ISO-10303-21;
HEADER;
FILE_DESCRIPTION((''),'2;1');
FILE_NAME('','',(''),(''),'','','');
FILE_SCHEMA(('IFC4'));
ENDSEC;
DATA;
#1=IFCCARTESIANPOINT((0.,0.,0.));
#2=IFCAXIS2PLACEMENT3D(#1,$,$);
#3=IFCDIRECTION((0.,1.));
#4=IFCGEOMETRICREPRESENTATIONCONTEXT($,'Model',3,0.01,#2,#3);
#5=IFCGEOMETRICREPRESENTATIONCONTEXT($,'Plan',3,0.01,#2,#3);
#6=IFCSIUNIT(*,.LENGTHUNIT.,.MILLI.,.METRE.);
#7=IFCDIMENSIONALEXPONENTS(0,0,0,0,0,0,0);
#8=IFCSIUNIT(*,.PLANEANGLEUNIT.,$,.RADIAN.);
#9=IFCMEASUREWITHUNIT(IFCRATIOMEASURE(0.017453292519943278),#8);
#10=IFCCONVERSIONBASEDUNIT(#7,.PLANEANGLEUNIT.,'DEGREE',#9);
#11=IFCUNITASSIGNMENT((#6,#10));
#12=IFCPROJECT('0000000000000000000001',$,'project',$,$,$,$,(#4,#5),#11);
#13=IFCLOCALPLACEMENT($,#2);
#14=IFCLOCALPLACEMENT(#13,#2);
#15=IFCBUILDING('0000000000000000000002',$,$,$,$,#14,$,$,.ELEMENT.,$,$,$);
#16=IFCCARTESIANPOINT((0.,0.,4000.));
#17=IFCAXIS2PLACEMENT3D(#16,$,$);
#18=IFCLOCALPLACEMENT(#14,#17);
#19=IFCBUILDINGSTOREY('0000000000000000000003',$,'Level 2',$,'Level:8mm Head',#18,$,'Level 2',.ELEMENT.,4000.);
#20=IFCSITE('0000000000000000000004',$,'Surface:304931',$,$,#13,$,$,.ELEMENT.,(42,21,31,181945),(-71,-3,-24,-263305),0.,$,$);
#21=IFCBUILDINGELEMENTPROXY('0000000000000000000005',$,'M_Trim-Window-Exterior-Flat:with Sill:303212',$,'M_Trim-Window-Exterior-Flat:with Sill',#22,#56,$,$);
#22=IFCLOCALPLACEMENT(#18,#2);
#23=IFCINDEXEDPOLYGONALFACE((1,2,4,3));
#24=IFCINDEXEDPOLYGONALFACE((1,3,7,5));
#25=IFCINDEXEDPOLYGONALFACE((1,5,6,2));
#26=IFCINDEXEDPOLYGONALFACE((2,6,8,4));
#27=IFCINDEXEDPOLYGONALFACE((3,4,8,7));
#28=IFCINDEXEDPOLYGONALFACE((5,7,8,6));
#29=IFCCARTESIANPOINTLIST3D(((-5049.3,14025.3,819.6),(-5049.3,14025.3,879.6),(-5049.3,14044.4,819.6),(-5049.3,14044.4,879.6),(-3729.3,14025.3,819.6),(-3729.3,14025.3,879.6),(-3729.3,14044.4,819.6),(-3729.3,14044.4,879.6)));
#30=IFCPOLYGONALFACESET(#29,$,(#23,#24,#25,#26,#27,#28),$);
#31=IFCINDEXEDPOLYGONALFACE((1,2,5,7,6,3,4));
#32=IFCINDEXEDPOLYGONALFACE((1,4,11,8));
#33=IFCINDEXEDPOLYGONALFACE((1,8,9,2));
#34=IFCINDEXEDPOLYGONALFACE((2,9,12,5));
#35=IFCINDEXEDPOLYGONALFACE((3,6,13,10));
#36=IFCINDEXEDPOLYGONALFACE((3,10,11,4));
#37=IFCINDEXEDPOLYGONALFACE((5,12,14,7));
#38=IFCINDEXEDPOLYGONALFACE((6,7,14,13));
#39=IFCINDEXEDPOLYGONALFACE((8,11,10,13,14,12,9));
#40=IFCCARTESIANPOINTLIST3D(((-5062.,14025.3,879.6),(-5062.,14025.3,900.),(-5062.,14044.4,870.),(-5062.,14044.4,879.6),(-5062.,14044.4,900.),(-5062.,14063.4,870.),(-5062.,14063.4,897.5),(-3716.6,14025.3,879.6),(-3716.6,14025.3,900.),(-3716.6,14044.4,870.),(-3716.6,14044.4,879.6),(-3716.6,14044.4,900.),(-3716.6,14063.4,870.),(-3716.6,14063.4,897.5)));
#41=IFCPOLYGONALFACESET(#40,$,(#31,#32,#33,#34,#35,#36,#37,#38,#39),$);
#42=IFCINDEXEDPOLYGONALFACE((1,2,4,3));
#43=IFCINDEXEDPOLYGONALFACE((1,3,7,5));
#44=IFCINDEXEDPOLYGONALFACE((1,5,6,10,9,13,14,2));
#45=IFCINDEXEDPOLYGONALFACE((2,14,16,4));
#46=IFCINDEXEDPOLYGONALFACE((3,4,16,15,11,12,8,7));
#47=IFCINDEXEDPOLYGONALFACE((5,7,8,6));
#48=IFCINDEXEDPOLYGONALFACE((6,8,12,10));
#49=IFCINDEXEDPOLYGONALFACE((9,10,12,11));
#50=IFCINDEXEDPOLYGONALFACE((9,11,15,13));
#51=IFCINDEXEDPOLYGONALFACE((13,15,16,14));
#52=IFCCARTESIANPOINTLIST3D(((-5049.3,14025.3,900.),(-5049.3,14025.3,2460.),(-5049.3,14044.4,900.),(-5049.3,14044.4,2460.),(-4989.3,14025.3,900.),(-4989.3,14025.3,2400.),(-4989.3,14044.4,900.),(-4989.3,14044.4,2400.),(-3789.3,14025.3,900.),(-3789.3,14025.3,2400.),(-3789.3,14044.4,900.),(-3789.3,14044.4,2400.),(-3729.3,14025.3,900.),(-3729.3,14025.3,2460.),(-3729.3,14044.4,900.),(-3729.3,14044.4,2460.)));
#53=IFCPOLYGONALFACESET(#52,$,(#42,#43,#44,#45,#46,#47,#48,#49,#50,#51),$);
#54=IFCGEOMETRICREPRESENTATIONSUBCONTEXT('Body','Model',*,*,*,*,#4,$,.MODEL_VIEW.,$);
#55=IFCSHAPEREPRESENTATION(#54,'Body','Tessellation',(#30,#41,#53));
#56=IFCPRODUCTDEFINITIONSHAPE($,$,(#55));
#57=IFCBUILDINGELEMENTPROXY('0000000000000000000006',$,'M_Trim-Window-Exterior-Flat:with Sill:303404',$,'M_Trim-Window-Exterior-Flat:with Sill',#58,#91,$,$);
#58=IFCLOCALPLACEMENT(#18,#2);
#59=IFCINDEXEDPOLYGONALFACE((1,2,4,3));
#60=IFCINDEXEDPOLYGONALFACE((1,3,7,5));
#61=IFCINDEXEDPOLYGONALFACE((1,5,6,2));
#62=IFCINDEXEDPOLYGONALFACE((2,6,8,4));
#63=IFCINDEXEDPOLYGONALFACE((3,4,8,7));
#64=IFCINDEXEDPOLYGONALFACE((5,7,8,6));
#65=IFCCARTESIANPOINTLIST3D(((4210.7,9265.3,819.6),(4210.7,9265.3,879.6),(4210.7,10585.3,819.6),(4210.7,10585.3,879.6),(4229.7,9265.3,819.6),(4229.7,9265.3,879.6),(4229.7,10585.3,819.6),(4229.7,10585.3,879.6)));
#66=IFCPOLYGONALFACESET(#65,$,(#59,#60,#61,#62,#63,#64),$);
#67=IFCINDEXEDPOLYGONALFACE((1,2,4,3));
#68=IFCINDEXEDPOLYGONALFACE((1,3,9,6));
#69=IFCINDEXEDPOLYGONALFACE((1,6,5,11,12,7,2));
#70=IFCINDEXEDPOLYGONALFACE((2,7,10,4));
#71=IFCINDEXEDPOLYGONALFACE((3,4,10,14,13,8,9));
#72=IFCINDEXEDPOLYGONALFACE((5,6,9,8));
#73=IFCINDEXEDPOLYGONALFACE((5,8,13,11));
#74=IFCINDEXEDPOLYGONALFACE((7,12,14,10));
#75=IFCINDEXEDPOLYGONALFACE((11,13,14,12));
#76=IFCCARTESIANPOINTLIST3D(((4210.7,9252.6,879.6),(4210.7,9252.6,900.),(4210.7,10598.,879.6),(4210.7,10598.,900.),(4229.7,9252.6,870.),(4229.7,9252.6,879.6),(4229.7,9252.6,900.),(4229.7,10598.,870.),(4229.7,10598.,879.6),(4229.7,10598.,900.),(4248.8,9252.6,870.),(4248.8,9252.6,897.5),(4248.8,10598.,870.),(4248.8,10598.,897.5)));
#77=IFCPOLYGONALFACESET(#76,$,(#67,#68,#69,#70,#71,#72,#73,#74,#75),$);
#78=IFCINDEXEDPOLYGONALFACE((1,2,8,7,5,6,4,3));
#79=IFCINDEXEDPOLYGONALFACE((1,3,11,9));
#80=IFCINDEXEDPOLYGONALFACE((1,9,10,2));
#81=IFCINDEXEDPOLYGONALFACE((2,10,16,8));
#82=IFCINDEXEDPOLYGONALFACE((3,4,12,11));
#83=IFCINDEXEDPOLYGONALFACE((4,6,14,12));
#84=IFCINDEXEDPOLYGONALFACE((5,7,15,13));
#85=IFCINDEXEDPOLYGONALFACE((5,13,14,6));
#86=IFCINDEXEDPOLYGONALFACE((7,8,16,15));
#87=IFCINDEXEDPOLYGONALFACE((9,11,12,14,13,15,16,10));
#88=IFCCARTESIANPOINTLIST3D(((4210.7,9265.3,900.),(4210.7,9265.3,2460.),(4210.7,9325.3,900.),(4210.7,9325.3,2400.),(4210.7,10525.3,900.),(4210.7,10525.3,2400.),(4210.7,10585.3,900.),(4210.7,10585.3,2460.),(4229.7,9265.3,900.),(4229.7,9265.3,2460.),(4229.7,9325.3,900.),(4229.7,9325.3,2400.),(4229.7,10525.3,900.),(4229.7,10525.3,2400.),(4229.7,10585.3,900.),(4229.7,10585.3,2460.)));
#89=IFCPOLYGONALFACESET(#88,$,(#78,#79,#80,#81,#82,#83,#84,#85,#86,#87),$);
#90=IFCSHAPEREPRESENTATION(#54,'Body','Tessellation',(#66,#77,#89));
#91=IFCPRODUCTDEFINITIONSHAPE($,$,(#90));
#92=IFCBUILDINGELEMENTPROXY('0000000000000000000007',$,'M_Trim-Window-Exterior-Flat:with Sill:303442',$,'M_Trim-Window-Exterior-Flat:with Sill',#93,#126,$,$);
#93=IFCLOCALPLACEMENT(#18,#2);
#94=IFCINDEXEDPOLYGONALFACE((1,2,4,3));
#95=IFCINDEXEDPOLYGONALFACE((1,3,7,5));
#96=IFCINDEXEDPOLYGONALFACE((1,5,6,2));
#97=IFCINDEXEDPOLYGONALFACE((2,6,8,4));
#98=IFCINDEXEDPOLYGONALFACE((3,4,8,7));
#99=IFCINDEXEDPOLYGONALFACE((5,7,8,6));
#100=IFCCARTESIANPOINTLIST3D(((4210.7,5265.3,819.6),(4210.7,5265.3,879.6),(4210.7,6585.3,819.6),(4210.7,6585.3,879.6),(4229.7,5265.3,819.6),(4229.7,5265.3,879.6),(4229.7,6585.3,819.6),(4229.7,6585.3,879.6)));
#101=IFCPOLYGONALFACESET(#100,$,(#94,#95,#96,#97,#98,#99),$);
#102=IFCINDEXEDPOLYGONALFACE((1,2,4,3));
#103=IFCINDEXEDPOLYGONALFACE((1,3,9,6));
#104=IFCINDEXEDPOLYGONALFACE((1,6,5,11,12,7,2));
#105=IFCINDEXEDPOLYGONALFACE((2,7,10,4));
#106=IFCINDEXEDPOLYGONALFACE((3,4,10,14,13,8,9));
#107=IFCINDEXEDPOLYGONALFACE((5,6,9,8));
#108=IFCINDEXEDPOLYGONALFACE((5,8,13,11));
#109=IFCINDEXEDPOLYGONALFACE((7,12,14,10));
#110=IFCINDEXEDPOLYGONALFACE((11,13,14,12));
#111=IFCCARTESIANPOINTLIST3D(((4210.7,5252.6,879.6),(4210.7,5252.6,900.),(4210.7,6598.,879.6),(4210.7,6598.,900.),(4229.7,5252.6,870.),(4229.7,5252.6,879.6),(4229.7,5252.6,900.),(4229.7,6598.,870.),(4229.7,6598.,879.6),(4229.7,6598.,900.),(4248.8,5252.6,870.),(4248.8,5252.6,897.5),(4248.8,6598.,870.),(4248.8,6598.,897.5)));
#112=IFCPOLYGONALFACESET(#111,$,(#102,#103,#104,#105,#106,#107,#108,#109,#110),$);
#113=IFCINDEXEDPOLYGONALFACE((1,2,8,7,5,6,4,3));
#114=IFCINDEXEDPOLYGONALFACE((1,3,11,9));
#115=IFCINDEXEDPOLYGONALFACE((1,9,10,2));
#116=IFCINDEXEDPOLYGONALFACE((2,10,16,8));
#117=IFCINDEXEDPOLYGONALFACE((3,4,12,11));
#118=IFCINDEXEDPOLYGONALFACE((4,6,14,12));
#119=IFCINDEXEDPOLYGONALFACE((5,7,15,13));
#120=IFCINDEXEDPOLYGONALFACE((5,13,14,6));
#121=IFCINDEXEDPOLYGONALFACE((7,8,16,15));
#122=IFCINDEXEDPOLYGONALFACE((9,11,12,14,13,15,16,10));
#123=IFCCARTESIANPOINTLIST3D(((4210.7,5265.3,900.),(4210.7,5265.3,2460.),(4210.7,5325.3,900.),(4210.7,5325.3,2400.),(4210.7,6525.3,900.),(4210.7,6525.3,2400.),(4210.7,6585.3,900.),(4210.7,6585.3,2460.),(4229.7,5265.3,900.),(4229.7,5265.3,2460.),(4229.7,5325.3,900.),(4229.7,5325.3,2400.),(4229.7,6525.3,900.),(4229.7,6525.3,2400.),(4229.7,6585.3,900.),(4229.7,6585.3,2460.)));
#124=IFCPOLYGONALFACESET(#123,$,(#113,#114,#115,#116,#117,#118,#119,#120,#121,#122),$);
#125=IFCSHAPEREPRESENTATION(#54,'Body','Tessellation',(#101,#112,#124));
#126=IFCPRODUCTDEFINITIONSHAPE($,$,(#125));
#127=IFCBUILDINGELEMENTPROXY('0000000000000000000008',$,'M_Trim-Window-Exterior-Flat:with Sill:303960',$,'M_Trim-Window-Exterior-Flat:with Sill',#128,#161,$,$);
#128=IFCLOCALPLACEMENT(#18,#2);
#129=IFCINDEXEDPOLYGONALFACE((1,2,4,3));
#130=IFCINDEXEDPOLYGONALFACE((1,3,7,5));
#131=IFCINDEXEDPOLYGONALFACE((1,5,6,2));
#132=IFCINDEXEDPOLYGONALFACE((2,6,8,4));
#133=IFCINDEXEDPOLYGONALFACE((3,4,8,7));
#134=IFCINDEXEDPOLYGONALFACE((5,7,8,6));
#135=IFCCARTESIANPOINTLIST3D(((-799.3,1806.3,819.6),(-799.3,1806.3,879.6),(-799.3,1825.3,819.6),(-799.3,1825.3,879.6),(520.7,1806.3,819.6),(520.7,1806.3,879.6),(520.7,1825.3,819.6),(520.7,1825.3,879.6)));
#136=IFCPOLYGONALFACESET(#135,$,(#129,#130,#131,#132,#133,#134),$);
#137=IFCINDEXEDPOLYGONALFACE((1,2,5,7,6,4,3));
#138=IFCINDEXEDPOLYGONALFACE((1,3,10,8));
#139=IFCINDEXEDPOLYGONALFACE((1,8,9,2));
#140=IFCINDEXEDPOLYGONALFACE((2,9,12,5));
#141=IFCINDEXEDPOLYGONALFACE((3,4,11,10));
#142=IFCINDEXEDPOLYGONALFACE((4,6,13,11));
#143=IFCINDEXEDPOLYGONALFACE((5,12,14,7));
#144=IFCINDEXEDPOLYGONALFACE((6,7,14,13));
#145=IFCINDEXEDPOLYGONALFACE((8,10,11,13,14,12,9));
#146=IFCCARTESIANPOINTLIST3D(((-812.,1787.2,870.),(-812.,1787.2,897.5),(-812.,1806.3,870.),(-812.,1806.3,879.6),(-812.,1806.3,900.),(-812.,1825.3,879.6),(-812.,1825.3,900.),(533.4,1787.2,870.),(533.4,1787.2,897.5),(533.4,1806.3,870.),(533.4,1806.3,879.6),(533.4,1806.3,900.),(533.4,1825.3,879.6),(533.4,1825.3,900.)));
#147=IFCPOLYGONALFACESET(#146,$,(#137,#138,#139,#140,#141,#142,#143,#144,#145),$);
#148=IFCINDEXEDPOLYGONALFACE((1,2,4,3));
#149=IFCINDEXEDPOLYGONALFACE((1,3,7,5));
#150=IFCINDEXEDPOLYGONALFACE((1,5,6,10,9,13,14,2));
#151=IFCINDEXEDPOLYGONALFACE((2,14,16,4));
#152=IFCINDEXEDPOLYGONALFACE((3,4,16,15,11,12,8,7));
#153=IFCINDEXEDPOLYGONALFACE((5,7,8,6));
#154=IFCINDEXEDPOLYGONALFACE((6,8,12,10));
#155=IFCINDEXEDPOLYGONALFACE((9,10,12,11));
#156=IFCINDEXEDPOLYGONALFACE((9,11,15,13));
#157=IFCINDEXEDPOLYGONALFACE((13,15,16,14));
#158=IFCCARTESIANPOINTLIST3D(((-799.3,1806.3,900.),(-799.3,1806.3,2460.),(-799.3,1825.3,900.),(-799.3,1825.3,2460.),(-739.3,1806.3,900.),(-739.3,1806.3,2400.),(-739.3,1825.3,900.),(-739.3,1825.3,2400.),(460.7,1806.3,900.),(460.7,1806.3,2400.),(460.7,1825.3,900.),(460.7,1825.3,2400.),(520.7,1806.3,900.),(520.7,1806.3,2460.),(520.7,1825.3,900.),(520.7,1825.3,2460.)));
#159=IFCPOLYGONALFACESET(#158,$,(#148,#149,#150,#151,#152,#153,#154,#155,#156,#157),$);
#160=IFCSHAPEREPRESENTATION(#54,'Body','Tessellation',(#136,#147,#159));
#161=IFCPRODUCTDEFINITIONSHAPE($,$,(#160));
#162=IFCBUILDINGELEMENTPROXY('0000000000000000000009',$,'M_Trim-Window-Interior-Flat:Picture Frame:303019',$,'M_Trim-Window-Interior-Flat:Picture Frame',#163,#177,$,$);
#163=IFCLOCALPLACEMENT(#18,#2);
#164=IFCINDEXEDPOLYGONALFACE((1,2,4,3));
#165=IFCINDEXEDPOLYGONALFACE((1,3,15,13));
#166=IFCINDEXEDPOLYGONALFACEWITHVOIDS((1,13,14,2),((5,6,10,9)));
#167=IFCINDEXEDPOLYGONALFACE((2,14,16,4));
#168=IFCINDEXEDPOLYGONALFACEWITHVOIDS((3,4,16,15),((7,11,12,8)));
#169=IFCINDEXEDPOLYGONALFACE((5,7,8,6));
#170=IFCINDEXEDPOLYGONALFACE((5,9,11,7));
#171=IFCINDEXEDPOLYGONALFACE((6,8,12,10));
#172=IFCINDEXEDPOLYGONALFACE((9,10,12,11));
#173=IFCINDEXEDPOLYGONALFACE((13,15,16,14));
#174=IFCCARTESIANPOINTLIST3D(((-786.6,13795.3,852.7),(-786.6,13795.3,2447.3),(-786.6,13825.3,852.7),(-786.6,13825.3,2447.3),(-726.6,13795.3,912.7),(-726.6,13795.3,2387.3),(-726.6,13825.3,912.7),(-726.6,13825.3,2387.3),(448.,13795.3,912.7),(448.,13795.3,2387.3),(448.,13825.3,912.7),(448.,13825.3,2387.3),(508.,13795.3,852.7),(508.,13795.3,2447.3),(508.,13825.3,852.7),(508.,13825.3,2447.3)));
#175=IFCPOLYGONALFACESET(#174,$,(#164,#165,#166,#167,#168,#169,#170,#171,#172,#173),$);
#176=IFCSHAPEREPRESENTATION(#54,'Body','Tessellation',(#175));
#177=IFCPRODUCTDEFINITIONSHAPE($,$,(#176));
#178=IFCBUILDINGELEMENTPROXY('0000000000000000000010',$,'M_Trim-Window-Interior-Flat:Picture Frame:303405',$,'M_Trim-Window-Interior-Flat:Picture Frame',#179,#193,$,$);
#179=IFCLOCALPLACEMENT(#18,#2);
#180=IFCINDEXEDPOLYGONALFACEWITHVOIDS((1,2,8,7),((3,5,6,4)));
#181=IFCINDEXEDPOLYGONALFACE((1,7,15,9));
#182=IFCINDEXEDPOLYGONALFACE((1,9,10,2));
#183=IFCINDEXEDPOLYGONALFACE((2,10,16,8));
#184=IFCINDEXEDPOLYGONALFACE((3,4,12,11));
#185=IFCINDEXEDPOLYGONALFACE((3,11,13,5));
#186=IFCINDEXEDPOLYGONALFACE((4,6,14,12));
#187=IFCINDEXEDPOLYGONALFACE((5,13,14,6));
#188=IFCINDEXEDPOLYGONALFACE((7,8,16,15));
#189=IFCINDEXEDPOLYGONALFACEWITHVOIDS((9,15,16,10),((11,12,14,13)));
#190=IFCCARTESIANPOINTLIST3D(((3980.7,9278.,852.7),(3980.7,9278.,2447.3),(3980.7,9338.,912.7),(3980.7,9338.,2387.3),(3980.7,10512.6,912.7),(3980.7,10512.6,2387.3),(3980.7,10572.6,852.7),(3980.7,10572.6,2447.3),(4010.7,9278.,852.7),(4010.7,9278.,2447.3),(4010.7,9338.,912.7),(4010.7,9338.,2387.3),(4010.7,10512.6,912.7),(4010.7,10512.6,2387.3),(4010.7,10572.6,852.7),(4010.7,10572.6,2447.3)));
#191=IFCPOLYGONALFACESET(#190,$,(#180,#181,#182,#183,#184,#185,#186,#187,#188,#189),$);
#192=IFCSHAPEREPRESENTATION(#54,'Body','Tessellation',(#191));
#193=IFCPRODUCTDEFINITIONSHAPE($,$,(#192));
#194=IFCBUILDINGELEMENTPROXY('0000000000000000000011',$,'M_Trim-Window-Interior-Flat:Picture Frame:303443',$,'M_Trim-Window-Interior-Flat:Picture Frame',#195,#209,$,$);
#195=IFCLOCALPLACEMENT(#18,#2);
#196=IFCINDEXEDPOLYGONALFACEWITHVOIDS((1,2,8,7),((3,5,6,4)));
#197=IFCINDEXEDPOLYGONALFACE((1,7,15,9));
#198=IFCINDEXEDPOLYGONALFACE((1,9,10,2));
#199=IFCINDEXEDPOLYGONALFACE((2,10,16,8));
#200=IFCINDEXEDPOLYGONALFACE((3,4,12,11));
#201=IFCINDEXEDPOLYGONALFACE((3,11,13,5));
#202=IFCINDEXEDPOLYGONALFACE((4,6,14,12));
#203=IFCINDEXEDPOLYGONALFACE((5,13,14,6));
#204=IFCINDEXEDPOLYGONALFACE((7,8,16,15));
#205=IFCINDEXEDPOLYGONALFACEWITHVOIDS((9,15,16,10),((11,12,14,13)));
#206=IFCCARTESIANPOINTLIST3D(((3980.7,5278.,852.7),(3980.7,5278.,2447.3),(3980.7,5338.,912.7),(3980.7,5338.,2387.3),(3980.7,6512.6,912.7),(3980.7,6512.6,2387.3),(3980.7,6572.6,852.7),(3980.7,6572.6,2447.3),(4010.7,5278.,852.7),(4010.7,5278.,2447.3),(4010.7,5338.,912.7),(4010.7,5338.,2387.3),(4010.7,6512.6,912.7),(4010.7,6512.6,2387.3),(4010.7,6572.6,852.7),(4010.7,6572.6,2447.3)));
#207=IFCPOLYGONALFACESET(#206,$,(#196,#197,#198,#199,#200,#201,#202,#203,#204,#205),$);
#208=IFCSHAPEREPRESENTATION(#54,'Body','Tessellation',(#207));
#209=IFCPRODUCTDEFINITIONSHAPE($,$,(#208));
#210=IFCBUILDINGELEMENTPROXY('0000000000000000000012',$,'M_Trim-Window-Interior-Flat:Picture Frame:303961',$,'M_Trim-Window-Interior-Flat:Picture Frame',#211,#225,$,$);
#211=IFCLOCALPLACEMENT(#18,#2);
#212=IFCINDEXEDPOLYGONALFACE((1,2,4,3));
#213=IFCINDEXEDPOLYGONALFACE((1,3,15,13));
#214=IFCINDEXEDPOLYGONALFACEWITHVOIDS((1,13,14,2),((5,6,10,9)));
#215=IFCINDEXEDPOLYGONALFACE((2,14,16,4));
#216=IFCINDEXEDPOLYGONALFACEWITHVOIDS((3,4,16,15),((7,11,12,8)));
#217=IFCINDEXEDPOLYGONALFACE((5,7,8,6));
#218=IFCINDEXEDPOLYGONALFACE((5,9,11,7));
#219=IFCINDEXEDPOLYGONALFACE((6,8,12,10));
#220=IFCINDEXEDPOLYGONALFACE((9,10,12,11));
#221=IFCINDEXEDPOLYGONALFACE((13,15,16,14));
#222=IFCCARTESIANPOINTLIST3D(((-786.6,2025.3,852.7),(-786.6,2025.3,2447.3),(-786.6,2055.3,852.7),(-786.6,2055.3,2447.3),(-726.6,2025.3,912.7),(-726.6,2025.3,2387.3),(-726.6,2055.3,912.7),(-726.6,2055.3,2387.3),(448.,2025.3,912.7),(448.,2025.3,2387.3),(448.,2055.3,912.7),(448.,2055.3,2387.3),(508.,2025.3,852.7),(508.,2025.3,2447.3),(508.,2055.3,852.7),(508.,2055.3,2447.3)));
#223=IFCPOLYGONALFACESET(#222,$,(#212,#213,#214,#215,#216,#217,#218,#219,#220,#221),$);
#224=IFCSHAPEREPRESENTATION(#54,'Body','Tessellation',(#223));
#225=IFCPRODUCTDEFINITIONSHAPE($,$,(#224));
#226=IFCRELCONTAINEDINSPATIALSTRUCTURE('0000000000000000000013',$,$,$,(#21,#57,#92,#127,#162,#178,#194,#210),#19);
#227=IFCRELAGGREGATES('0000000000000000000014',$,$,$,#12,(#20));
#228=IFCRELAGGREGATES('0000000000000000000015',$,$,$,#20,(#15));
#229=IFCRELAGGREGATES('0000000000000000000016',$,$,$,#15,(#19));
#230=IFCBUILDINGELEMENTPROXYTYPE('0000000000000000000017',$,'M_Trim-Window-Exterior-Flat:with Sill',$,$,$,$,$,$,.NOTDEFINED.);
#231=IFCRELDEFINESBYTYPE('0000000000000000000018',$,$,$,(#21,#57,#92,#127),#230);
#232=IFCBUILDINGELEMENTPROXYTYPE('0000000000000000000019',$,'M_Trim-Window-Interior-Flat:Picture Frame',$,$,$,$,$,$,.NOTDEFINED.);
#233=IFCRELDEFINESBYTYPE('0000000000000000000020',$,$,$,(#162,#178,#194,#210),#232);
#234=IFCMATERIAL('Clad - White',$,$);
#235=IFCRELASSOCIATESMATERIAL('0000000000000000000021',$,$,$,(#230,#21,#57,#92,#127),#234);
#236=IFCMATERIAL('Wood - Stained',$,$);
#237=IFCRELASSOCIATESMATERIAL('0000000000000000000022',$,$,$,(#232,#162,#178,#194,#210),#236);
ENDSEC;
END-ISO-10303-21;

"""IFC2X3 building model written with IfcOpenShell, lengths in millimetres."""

from ifc_helpers import new_model, entity, si_unit, converted_unit, direction, frame, frame_2d, origin, place, context, subcontext, project, spatial, polyline, rectangle, outline, extrude, source, transform, mapped, material, type_object, type_shapes, element, save


model = new_model("IFC2X3")

# Units and contexts
model_context = context("Model", 3, precision=0.01, world=origin(), true_north=direction((0.0, 1.0)))
plan_context = context("Plan", 3, precision=0.01, world=origin(), true_north=direction((0.0, 1.0)))
body_context = subcontext(model_context, "Body", "Model", "MODEL_VIEW")
ifc_project = project(units=[si_unit("LENGTHUNIT", "METRE", prefix="MILLI"), converted_unit("PLANEANGLEUNIT", "DEGREE", entity("IfcRatioMeasure", 0.017453292519943278), si_unit("PLANEANGLEUNIT", "RADIAN"), dimensions=[0, 0, 0, 0, 0, 0, 0])], contexts=[model_context, plan_context])

# Site, building, storey
site_placement = place(None, origin())
site = spatial("IfcSite", under=ifc_project, at=site_placement, Name="Surface:304931", CompositionType="ELEMENT", RefLatitude=(42, 21, 31, 181945), RefLongitude=(-71, -3, -24, -263305), RefElevation=0.0)
building_placement = place(site_placement, origin())
building = spatial("IfcBuilding", under=site, at=building_placement, CompositionType="ELEMENT")
storey_placement = place(building_placement, frame((0.0, 0.0, 4000.0)))
storey = spatial("IfcBuildingStorey", under=building, at=storey_placement, Name="Level 2", ObjectType="Level:8mm Head", LongName="Level 2", CompositionType="ELEMENT", Elevation=4000.0)

# Building element proxies
ifc_material_1 = material(Name="Clad - White")
ifc_material_2 = material(Name="Wood - Stained")
building_element_proxy_type_1 = type_object("IfcBuildingElementProxyType", Name="M_Trim-Window-Exterior-Flat:with Sill", PredefinedType="NOTDEFINED", material=ifc_material_1)
shared_shape_1 = source(origin(), body_context, "Body", "SweptSolid", [
    extrude(rectangle(XDim=1320.0, YDim=60.0, at=frame_2d((0.0, 0.0), x_axis=(1.0, 0.0))), frame((0.0, -1550.4, 0.0), z_axis=(0.0, 0.0, 1.0), x_axis=(-1.0, 0.0, 0.0)), (0.0, 0.0, 1.0), 19.0),
    extrude(outline(polyline([(-19.0, -15.2), (0.0, -15.2), (0.0, -5.7), (19.0, -5.7), (19.0, 14.8), (0.0, 14.8), (-19.0, 12.3), (-19.0, -15.2)])), frame((-672.7, -1514.8, 19.0), z_axis=(1.0, 0.0, 0.0), x_axis=(0.0, 0.0, -1.0)), (0.0, 0.0, 1.0), 1345.4),
    extrude(outline(polyline([(-795.0, -660.0), (765.0, -660.0), (765.0, -600.0), (-735.0, -600.0), (-735.0, 600.0), (765.0, 600.0), (765.0, 660.0), (-795.0, 660.0), (-795.0, -660.0)])), frame((0.0, -735.0, 0.0), z_axis=(0.0, 0.0, 1.0), x_axis=(0.0, -1.0, 0.0)), (0.0, 0.0, 1.0), 19.0),
])
type_shapes(building_element_proxy_type_1, [shared_shape_1])
for number, where, z_axis, x_axis, name in (
    (1, (-4389.3, 14025.3, 2400.0), (0.0, 1.0, 0.0), (-1.0, 0.0, 0.0), "M_Trim-Window-Exterior-Flat:with Sill:303212"),
    (2, (4210.7, 9925.3, 2400.0), (1.0, 0.0, 0.0), (0.0, 1.0, 0.0), "M_Trim-Window-Exterior-Flat:with Sill:303404"),
    (3, (4210.7, 5925.3, 2400.0), (1.0, 0.0, 0.0), (0.0, 1.0, 0.0), "M_Trim-Window-Exterior-Flat:with Sill:303442"),
    (4, (-139.3, 1825.3, 2400.0), (0.0, -1.0, 0.0), (1.0, 0.0, 0.0), "M_Trim-Window-Exterior-Flat:with Sill:303960"),
):
    element("IfcBuildingElementProxy", number, at=place(storey_placement, frame(where, z_axis=z_axis, x_axis=x_axis)), inside=storey, type_object=building_element_proxy_type_1, material=ifc_material_1, Name=name, ObjectType="M_Trim-Window-Exterior-Flat:with Sill", context=body_context, shape_type="MappedRepresentation", body=[
        mapped(shared_shape_1, transform((0.0, 0.0, 0.0), scale=1.0)),
    ])
building_element_proxy_type_2 = type_object("IfcBuildingElementProxyType", Name="M_Trim-Window-Interior-Flat:Picture Frame", PredefinedType="NOTDEFINED", material=ifc_material_2)
shared_shape_2 = source(origin(), body_context, "Body", "SweptSolid", [
    extrude(outline(polyline([(-647.3, -797.3), (647.3, -797.3), (647.3, 797.3), (-647.3, 797.3), (-647.3, -797.3)]), holes=[polyline([(-587.3, -737.3), (-587.3, 737.3), (587.3, 737.3), (587.3, -737.3), (-587.3, -737.3)])]), frame((0.0, -750.0, 0.0), z_axis=(0.0, 0.0, 1.0), x_axis=(-1.0, 0.0, 0.0)), (0.0, 0.0, 1.0), 30.0),
])
type_shapes(building_element_proxy_type_2, [shared_shape_2])
for number, where, z_axis, x_axis, name in (
    (5, (-139.3, 13825.3, 2400.0), (0.0, -1.0, 0.0), (1.0, 0.0, 0.0), "M_Trim-Window-Interior-Flat:Picture Frame:303019"),
    (6, (4010.7, 9925.3, 2400.0), (-1.0, 0.0, 0.0), (0.0, -1.0, 0.0), "M_Trim-Window-Interior-Flat:Picture Frame:303405"),
    (7, (4010.7, 5925.3, 2400.0), (-1.0, 0.0, 0.0), (0.0, -1.0, 0.0), "M_Trim-Window-Interior-Flat:Picture Frame:303443"),
    (8, (-139.3, 2025.3, 2400.0), (0.0, 1.0, 0.0), (-1.0, 0.0, 0.0), "M_Trim-Window-Interior-Flat:Picture Frame:303961"),
):
    element("IfcBuildingElementProxy", number, at=place(storey_placement, frame(where, z_axis=z_axis, x_axis=x_axis)), inside=storey, type_object=building_element_proxy_type_2, material=ifc_material_2, Name=name, ObjectType="M_Trim-Window-Interior-Flat:Picture Frame", context=body_context, shape_type="MappedRepresentation", body=[
        mapped(shared_shape_2, transform((0.0, 0.0, 0.0), scale=1.0)),
    ])

save(model, "model.ifc")
